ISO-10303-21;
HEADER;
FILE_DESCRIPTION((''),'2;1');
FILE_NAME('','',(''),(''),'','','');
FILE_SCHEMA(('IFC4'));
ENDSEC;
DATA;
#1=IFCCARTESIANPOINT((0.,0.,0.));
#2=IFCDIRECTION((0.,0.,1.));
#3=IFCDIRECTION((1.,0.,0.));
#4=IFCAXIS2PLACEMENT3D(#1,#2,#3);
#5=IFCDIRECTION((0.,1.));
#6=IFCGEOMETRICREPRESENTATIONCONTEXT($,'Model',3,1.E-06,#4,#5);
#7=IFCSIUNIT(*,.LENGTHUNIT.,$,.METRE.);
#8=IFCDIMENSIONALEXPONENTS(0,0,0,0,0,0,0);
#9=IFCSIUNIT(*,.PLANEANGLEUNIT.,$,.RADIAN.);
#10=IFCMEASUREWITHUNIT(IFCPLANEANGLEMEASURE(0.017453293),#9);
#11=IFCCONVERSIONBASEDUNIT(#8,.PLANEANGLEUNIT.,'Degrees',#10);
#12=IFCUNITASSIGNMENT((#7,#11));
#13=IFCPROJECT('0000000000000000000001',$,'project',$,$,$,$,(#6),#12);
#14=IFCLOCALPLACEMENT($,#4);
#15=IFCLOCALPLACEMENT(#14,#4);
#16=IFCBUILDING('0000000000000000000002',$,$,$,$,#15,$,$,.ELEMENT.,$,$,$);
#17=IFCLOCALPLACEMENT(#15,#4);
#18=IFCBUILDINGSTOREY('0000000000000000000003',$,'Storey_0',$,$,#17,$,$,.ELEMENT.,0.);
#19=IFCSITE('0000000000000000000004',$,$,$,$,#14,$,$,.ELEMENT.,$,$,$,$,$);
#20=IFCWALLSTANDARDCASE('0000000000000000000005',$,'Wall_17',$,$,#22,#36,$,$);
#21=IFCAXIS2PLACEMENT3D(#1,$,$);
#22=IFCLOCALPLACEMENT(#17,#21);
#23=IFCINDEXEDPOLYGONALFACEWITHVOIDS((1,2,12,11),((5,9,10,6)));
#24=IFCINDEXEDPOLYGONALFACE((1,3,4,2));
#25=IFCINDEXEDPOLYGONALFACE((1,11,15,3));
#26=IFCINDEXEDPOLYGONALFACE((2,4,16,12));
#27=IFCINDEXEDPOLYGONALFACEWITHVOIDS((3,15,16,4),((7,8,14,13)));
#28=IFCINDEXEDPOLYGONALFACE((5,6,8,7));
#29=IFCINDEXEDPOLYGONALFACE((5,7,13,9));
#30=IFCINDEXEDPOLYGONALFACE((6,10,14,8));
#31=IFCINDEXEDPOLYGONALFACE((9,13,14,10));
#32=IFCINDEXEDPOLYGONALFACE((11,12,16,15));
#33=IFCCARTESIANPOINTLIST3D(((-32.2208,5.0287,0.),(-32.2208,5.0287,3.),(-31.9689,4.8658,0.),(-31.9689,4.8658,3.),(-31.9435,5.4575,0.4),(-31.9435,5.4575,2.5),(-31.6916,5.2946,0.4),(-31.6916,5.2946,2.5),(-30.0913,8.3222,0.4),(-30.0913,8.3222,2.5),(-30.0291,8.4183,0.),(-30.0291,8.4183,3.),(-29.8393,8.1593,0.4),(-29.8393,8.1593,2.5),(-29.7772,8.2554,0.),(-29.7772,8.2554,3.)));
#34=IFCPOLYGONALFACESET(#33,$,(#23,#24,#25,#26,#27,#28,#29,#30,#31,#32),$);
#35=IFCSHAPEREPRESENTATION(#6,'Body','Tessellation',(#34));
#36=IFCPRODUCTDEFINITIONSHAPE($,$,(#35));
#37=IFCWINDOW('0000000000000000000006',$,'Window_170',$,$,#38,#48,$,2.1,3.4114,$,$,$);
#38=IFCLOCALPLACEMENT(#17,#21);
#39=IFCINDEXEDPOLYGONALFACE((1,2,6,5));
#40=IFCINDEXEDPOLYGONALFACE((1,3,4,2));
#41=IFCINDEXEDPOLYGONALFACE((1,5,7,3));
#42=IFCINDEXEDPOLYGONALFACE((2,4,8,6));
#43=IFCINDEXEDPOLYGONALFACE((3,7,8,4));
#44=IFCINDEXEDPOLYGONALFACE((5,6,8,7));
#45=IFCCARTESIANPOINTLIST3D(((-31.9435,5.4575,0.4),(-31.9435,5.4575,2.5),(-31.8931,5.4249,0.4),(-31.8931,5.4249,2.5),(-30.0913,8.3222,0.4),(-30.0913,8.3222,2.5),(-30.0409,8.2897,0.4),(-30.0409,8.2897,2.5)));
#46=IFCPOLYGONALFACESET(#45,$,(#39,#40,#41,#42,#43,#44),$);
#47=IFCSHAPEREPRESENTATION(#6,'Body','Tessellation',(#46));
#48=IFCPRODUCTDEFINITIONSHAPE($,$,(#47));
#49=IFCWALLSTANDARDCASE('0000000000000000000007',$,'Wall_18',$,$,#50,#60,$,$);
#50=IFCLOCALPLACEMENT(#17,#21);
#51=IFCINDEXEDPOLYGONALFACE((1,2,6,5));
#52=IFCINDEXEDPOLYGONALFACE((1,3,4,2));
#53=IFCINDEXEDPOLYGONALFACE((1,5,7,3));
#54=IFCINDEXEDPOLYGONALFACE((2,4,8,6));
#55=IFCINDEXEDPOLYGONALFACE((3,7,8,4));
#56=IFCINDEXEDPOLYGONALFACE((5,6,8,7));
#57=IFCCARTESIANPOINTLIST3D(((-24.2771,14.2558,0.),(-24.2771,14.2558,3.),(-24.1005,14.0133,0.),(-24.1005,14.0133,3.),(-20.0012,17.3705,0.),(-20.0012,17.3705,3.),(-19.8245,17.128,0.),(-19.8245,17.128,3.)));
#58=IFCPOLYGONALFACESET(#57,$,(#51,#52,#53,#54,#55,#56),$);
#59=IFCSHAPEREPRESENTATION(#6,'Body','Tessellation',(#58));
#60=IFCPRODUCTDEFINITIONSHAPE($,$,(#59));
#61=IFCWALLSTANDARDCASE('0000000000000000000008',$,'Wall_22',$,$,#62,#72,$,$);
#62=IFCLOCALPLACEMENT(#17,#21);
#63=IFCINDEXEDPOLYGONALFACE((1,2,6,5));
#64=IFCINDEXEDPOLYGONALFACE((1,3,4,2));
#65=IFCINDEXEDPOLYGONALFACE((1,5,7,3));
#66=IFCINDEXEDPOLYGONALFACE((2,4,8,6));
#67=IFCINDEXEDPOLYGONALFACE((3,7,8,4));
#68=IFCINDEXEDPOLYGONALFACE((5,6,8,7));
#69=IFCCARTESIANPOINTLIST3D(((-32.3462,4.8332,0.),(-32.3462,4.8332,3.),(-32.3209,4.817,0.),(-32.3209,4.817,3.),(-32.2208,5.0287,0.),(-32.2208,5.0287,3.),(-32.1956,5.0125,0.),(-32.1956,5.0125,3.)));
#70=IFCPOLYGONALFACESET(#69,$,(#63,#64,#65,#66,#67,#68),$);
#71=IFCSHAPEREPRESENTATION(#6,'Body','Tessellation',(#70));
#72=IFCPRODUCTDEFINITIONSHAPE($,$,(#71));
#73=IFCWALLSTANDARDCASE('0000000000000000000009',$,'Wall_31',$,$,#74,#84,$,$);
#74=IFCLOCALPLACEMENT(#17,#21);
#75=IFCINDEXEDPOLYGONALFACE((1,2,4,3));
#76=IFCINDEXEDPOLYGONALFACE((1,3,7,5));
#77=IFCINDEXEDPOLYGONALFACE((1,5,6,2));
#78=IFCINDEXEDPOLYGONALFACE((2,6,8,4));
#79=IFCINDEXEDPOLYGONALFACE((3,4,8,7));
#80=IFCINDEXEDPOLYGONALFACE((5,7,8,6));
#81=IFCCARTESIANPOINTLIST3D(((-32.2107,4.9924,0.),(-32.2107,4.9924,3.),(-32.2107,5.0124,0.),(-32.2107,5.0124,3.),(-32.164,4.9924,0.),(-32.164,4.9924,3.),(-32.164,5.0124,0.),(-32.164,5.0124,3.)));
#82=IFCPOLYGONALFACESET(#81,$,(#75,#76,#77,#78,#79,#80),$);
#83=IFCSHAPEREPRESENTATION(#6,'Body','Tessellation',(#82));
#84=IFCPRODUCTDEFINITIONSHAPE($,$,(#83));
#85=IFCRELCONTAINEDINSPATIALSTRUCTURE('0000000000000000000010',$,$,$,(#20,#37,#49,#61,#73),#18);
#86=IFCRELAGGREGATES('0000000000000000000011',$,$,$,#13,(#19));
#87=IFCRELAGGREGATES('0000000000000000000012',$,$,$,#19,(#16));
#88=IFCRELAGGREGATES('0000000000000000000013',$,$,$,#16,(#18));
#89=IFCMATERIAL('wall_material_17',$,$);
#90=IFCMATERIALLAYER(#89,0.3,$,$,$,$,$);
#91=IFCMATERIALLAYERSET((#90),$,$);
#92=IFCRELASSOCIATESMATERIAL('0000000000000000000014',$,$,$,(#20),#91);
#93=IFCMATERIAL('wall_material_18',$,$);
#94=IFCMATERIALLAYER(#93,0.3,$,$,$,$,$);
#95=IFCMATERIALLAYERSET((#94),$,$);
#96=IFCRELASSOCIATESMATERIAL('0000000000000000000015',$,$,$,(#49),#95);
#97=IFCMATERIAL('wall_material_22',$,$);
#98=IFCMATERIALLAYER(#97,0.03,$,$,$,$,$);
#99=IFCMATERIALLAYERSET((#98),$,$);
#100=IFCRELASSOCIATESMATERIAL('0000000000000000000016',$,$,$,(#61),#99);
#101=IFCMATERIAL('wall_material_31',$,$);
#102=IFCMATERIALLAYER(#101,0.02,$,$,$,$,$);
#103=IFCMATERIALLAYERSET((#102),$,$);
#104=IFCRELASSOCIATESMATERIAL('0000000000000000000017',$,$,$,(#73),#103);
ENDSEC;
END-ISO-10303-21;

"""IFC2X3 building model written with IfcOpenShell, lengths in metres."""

from ifc_helpers import new_model, entity, si_unit, converted_unit, direction, frame, frame_2d, origin_with_axes, place, context, project, spatial, polyline, rectangle, outline, extrude, material, layer, layer_set, layer_usage, element, fill, save


model = new_model("IFC2X3")

# Units and contexts
model_context = context("Model", 3, precision=1e-06, world=origin_with_axes(), true_north=direction((0.0, 1.0)))
ifc_project = project(units=[si_unit("LENGTHUNIT", "METRE"), converted_unit("PLANEANGLEUNIT", "Degrees", entity("IfcPlaneAngleMeasure", 0.017453293), si_unit("PLANEANGLEUNIT", "RADIAN"), dimensions=[0, 0, 0, 0, 0, 0, 0])], contexts=[model_context])

# Site, building, storey
site_placement = place(None, origin_with_axes())
site = spatial("IfcSite", under=ifc_project, at=site_placement, CompositionType="ELEMENT")
building_placement = place(site_placement, origin_with_axes())
building = spatial("IfcBuilding", under=site, at=building_placement, CompositionType="ELEMENT")
storey_placement = place(building_placement, origin_with_axes())
storey = spatial("IfcBuildingStorey", under=building, at=storey_placement, Name="Storey_0", CompositionType="ELEMENT", Elevation=0.0)

# Wall, opening, window
ifc_material_1 = material(Name="wall_material_17")
ifc_layer_1 = layer(ifc_material_1, 0.3)
ifc_layer_set_1 = layer_set([ifc_layer_1])
ifc_layer_usage_1 = layer_usage(ifc_layer_set_1, "AXIS2", "NEGATIVE", 0.0)
wall_1_placement = place(storey_placement, frame((-32.2208, 5.0287, 0.0), z_axis=(0.0, 0.0, 1.0), x_axis=(0.542966, 0.839754, 0.0)))
wall_1 = element("IfcWallStandardCase", 1, at=wall_1_placement, inside=storey, material=ifc_layer_usage_1, Name="Wall_17", context=model_context, shape_type="SweptSolid", body=[
    extrude(outline(polyline([(0.0, 0.0), (4.0365, 0.0), (4.0365, -0.3), (0.0, -0.3), (0.0, 0.0)])), origin_with_axes(), (0.0, 0.0, 1.0), 3.0),
])
opening_1_placement = place(wall_1_placement, frame((0.5107, 0.0, 0.4), z_axis=(0.0, 0.0, 1.0), x_axis=(1.0, 0.0, 0.0)))
opening_1 = element("IfcOpeningElement", 2, at=opening_1_placement, cuts=wall_1, context=model_context, shape_type="SweptSolid", body=[
    extrude(rectangle(XDim=3.4114, YDim=2.1, at=frame_2d((1.05, -1.7057), x_axis=(0.0, 1.0))), frame((0.0, 0.01, 0.0), z_axis=(0.0, -1.0, 0.0), x_axis=(0.0, 0.0, 1.0)), (0.0, 0.0, 1.0), 0.32),
])
window_1_placement = place(storey_placement, frame((0.0, 0.0, 0.4), z_axis=(0.0, 0.0, 1.0), x_axis=(1.0, 0.0, 0.0)))
window_1 = element("IfcWindow", 3, at=window_1_placement, inside=storey, Name="Window_170", OverallHeight=2.1, OverallWidth=3.4114, context=model_context, shape_type="SweptSolid", body=[
    extrude(outline(polyline([(-31.9435, 5.4575), (-30.0913, 8.3222), (-30.0409, 8.2897), (-31.8931, 5.4249), (-31.9435, 5.4575)])), origin_with_axes(), (0.0, 0.0, 1.0), 2.1),
])
fill(opening_1, window_1)

# Walls
ifc_material_2 = material(Name="wall_material_18")
ifc_layer_2 = layer(ifc_material_2, 0.3)
ifc_layer_set_2 = layer_set([ifc_layer_2])
ifc_layer_usage_2 = layer_usage(ifc_layer_set_2, "AXIS2", "NEGATIVE", 0.0)
wall_2_placement = place(storey_placement, frame((-24.2771, 14.2558, 0.0), z_axis=(0.0, 0.0, 1.0), x_axis=(0.808298, 0.588773, 0.0)))
element("IfcWallStandardCase", 4, at=wall_2_placement, inside=storey, material=ifc_layer_usage_2, Name="Wall_18", context=model_context, shape_type="SweptSolid", body=[
    extrude(outline(polyline([(0.0, 0.0), (5.2901, 0.0), (5.2901, -0.3), (0.0, -0.3), (0.0, 0.0)])), origin_with_axes(), (0.0, 0.0, 1.0), 3.0),
])
ifc_material_3 = material(Name="wall_material_22")
ifc_layer_3 = layer(ifc_material_3, 0.03)
ifc_layer_set_3 = layer_set([ifc_layer_3])
ifc_layer_usage_3 = layer_usage(ifc_layer_set_3, "AXIS2", "POSITIVE", 0.0)
wall_3_placement = place(storey_placement, frame((-32.2208, 5.0287, 0.0), z_axis=(0.0, 0.0, 1.0), x_axis=(-0.540007, -0.841661, 0.0)))
element("IfcWallStandardCase", 5, at=wall_3_placement, inside=storey, material=ifc_layer_usage_3, Name="Wall_22", context=model_context, shape_type="SweptSolid", body=[
    extrude(outline(polyline([(0.0, 0.03), (0.2322, 0.03), (0.2322, 0.0), (0.0, 0.0), (0.0, 0.03)])), origin_with_axes(), (0.0, 0.0, 1.0), 3.0),
])
ifc_material_4 = material(Name="wall_material_31")
ifc_layer_4 = layer(ifc_material_4, 0.02)
ifc_layer_set_4 = layer_set([ifc_layer_4])
ifc_layer_usage_4 = layer_usage(ifc_layer_set_4, "AXIS2", "POSITIVE", 0.0)
wall_4_placement = place(storey_placement, frame((-32.2107, 4.9924, 0.0), z_axis=(0.0, 0.0, 1.0), x_axis=(1.0, 0.0, 0.0)))
element("IfcWallStandardCase", 6, at=wall_4_placement, inside=storey, material=ifc_layer_usage_4, Name="Wall_31", context=model_context, shape_type="SweptSolid", body=[
    extrude(outline(polyline([(0.0, 0.02), (0.0467, 0.02), (0.0467, 0.0), (0.0, 0.0), (0.0, 0.02)])), origin_with_axes(), (0.0, 0.0, 1.0), 3.0),
])

save(model, "model.ifc")
